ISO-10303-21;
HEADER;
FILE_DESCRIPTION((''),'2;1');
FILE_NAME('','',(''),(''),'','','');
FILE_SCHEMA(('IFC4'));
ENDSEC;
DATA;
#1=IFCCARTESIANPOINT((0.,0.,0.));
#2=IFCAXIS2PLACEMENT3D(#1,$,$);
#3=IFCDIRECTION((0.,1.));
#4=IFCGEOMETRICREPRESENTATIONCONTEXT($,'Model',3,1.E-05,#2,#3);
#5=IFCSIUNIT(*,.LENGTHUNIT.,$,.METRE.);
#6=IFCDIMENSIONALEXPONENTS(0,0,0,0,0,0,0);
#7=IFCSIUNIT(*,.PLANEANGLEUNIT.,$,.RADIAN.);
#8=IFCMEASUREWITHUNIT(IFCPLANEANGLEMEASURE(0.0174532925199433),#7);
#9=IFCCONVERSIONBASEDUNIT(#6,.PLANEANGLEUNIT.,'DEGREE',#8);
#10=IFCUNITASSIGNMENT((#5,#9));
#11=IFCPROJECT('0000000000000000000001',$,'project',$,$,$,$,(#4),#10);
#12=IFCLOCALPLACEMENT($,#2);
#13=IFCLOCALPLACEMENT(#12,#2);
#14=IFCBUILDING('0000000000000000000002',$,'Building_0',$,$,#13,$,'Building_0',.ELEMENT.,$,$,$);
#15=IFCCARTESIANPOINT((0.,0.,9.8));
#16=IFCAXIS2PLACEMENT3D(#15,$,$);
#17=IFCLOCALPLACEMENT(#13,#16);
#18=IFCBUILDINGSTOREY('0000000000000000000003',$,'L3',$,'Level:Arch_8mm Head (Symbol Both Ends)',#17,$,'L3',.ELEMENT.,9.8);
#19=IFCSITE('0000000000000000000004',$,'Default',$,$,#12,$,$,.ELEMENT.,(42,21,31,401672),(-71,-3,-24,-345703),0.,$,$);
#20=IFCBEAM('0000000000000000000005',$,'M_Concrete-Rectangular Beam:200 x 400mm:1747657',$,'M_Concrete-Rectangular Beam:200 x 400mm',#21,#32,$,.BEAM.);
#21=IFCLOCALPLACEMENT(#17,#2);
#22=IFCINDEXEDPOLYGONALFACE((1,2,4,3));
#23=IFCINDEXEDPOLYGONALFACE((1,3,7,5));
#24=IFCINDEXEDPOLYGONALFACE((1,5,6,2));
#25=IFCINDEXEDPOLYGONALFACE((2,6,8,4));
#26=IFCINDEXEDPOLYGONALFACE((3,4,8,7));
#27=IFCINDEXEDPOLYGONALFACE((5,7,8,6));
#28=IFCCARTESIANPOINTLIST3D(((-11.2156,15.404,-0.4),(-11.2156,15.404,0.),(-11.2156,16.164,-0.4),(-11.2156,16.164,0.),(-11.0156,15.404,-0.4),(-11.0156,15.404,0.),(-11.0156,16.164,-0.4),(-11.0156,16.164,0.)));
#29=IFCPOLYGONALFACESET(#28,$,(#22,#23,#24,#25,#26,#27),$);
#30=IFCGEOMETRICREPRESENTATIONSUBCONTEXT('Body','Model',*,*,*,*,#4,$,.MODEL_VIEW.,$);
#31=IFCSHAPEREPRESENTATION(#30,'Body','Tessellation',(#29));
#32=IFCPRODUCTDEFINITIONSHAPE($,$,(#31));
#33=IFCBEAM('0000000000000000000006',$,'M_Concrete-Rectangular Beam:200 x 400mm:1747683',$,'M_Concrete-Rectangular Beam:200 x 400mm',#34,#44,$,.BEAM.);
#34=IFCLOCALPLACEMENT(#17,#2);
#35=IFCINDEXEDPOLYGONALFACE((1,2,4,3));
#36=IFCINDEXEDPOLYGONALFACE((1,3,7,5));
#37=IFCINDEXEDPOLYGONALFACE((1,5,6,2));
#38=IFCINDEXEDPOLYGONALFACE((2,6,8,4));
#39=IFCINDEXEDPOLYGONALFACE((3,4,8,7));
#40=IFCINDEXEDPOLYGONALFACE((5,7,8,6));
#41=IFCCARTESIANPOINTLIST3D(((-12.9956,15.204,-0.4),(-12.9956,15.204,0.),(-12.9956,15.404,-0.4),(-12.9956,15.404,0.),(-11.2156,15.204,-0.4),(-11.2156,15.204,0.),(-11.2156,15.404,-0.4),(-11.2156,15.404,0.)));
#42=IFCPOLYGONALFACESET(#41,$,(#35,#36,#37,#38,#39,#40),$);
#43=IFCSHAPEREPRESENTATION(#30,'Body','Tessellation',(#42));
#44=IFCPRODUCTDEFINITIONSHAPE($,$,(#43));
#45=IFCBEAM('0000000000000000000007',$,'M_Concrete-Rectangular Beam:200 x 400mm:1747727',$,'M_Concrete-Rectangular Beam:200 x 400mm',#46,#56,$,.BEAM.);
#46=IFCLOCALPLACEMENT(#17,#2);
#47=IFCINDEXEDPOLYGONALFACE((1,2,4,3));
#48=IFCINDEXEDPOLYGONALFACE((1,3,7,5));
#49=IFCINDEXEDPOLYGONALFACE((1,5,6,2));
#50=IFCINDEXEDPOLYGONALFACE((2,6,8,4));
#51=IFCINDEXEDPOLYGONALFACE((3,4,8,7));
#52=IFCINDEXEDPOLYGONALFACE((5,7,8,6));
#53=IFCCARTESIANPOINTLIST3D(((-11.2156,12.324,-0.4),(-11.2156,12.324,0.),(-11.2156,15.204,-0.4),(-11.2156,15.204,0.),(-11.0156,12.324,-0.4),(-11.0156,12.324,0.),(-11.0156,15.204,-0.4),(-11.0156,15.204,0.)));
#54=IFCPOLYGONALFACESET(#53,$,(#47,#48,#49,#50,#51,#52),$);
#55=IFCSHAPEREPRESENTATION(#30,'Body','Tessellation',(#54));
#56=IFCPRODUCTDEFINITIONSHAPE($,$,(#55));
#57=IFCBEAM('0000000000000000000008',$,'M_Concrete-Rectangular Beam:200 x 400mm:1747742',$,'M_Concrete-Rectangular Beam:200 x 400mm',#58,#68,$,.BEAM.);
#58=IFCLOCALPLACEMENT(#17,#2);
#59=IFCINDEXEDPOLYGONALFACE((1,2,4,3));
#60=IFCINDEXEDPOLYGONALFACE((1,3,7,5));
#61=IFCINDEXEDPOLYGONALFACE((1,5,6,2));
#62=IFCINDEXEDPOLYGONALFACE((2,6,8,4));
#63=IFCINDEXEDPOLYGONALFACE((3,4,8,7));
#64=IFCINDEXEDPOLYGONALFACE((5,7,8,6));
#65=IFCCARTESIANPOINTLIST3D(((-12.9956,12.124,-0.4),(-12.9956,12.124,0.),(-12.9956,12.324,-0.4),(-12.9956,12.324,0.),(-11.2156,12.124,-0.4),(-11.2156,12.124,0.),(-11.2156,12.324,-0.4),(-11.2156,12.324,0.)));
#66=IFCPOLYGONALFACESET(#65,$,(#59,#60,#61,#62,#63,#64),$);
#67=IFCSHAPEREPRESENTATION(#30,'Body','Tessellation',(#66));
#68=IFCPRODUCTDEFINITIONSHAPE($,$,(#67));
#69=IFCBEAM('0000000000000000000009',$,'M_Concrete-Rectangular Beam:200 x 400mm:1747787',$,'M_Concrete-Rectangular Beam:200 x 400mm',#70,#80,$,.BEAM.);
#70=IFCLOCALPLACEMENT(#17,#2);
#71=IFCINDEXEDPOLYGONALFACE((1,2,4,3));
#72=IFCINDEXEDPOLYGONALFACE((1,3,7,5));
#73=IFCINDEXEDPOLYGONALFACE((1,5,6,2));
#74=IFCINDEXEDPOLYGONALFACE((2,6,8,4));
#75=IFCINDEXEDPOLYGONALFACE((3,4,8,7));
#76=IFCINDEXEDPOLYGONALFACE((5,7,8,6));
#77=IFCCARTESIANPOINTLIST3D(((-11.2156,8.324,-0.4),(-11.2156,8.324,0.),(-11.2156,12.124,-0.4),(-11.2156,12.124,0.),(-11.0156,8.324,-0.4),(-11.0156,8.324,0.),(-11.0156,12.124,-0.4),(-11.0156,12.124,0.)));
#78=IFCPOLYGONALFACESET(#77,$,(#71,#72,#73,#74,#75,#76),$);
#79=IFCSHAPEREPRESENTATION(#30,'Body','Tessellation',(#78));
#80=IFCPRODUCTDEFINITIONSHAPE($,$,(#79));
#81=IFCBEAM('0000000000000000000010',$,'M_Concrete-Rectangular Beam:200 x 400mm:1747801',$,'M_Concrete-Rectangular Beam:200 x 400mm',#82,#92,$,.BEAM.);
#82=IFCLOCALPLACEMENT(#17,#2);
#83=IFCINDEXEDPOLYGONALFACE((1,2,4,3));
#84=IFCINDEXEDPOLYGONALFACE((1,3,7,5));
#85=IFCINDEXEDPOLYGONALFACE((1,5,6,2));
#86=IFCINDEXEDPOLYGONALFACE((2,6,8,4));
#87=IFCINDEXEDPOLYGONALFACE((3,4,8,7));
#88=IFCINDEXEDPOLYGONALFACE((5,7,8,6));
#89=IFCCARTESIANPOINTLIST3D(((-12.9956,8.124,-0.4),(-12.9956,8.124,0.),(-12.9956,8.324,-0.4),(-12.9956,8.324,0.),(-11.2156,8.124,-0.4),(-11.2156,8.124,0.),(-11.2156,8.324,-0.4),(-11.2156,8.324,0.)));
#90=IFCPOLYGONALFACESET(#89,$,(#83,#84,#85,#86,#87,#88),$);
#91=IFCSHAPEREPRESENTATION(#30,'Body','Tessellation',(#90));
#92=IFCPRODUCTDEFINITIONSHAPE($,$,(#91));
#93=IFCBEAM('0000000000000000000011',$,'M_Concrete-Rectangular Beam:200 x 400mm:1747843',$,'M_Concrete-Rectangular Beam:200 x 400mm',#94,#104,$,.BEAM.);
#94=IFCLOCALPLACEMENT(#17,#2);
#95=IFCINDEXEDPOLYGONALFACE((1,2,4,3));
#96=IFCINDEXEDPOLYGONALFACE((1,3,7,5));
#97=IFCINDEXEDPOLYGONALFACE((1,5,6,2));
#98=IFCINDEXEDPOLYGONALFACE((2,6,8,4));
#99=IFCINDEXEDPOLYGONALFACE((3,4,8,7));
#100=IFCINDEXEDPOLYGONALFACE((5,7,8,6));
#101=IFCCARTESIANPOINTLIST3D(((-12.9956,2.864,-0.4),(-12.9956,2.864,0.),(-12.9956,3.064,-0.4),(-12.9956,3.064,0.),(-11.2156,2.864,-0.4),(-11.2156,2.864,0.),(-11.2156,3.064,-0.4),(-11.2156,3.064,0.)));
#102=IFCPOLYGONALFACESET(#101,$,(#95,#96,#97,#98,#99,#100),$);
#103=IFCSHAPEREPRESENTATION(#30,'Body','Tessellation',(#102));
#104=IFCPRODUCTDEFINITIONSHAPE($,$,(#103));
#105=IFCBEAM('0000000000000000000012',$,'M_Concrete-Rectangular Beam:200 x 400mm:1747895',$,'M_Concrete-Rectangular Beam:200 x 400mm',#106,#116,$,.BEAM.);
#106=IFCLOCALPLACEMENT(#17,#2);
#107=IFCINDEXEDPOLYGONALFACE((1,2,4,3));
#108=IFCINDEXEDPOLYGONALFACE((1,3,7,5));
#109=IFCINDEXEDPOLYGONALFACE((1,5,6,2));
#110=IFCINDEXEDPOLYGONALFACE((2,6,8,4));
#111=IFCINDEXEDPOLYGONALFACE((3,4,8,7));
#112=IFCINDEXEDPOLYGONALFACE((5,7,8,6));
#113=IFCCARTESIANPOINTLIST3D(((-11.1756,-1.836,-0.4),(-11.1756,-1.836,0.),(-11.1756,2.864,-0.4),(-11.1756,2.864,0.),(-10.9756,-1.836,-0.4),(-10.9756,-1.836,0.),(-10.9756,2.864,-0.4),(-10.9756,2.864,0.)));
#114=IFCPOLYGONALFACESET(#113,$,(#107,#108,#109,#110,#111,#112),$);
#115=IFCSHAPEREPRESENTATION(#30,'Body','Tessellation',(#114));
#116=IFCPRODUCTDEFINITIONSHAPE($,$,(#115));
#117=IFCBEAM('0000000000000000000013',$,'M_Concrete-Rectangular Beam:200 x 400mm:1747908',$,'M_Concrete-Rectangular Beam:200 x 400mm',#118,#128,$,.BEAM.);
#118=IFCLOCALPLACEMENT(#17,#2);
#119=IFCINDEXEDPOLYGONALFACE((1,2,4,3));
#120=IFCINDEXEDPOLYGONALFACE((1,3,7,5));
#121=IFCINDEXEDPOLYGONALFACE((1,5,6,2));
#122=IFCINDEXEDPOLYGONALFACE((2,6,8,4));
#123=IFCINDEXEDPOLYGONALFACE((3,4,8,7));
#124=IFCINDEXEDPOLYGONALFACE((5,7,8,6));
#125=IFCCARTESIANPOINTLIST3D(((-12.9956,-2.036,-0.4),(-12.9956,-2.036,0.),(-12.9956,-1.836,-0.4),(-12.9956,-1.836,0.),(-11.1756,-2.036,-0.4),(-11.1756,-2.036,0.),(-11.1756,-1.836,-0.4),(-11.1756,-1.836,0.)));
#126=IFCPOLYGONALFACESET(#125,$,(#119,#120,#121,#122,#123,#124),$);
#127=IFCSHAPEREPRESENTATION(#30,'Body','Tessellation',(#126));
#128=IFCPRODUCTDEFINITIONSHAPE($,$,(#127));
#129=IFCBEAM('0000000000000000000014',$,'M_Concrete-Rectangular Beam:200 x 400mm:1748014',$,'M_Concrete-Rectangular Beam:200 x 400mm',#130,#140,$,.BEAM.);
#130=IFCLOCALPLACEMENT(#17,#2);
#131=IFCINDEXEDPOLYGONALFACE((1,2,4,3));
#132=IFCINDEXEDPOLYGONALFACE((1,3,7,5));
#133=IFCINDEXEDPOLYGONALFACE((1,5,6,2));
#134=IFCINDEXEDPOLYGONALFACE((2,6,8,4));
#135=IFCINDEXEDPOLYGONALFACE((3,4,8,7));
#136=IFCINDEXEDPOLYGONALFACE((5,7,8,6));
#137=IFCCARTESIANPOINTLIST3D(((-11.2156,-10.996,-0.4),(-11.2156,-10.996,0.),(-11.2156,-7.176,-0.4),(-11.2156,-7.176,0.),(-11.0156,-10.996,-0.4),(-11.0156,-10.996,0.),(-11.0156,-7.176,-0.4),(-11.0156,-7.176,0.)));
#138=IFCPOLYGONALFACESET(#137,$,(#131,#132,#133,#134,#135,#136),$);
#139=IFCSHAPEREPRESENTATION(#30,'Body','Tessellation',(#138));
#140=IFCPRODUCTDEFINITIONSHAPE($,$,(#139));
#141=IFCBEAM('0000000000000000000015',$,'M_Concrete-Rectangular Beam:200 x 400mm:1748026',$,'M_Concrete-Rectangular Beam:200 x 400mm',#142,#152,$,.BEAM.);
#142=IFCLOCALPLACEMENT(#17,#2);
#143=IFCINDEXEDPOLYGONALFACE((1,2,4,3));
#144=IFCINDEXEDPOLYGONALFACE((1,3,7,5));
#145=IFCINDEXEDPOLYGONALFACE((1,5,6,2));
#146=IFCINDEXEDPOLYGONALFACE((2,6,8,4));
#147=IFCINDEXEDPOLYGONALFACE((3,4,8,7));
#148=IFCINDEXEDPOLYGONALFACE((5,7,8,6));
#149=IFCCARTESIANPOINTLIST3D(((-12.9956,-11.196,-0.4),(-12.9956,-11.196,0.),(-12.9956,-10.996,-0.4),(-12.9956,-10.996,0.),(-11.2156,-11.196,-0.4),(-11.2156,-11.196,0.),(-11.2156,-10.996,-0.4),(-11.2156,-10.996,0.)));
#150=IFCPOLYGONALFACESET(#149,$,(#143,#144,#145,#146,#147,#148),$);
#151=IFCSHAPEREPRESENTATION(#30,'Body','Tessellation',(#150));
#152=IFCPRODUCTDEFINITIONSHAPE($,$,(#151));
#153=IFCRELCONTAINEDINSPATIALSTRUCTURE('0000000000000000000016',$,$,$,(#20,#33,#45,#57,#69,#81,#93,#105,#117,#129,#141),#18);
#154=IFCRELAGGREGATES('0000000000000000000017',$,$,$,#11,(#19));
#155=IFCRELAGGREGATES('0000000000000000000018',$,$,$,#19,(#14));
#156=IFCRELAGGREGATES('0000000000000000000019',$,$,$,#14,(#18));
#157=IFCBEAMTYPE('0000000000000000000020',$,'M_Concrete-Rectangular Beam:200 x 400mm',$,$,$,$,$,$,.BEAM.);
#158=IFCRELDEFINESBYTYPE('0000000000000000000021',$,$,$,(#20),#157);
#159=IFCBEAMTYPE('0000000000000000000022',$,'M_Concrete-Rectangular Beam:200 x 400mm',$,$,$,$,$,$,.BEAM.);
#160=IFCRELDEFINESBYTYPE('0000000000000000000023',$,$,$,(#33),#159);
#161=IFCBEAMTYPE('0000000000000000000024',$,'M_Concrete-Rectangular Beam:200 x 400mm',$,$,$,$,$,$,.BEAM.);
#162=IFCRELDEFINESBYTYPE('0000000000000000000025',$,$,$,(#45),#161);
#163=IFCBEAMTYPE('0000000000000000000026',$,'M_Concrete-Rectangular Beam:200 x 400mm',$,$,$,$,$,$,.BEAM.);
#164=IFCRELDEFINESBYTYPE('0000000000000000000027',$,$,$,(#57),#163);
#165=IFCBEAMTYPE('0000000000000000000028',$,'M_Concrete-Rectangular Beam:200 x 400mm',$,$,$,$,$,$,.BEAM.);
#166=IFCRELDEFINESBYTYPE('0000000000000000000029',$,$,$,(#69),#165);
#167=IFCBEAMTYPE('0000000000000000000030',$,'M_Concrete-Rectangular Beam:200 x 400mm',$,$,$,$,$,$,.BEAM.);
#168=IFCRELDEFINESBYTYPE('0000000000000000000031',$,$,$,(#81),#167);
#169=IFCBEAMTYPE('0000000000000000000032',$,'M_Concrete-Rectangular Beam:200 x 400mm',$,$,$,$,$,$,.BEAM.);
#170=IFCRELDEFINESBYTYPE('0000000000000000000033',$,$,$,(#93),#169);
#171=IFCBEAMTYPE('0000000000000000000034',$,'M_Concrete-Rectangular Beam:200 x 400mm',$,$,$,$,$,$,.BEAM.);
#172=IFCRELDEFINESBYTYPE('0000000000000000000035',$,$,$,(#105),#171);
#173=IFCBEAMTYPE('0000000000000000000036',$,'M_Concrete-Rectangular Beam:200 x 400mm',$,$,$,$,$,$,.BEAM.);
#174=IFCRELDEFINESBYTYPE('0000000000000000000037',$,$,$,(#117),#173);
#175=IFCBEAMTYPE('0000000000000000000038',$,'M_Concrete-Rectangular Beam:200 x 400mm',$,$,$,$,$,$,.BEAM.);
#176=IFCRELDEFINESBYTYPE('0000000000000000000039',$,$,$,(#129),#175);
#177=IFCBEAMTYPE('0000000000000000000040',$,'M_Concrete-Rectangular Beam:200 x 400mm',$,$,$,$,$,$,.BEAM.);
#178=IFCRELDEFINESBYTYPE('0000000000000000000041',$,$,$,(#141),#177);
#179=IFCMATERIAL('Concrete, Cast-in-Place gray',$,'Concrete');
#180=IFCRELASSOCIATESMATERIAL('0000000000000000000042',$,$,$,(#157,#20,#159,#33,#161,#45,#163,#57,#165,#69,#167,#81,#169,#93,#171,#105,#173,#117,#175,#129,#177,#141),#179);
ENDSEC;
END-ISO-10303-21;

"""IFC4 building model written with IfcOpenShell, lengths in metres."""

from ifc_helpers import new_model, entity, si_unit, converted_unit, direction, frame, origin, place, context, subcontext, project, spatial, indexed_curve, outline, extrude, source, transform, mapped, material, type_object, type_shapes, element, save


model = new_model("IFC4")

# Units and contexts
model_context = context("Model", 3, precision=1e-05, world=origin(), true_north=direction((0.0, 1.0)))
body_context = subcontext(model_context, "Body", "Model", "MODEL_VIEW")
ifc_project = project(units=[si_unit("LENGTHUNIT", "METRE"), converted_unit("PLANEANGLEUNIT", "DEGREE", entity("IfcPlaneAngleMeasure", 0.0174532925199433), si_unit("PLANEANGLEUNIT", "RADIAN"), dimensions=[0, 0, 0, 0, 0, 0, 0])], contexts=[model_context])

# Site, building, storey
site_placement = place(None, origin())
site = spatial("IfcSite", under=ifc_project, at=site_placement, Name="Default", CompositionType="ELEMENT", RefLatitude=(42, 21, 31, 401672), RefLongitude=(-71, -3, -24, -345703), RefElevation=0.0)
building_placement = place(site_placement, origin())
building = spatial("IfcBuilding", under=site, at=building_placement, Name="Building_0", LongName="Building_0", CompositionType="ELEMENT")
storey_placement = place(building_placement, frame((0.0, 0.0, 9.8)))
storey = spatial("IfcBuildingStorey", under=building, at=storey_placement, Name="L3", ObjectType="Level:Arch_8mm Head (Symbol Both Ends)", LongName="L3", CompositionType="ELEMENT", Elevation=9.8)

# Beams
ifc_material_1 = material(Name="Concrete, Cast-in-Place gray", Category="Concrete")
beam_type_1 = type_object("IfcBeamType", Name="M_Concrete-Rectangular Beam:200 x 400mm", PredefinedType="BEAM", material=ifc_material_1)
shared_shape_1 = source(origin(), body_context, "Body", "SweptSolid", [
    extrude(outline(indexed_curve([(-0.1, -0.2), (0.1, -0.2), (0.1, 0.2), (-0.1, 0.2), (-0.1, -0.2)], self_intersect=False)), frame((-11.1156, 15.404, 9.6), z_axis=(0.0, 1.0, 0.0), x_axis=(-1.0, 0.0, 0.0)), (0.0, 0.0, 1.0), 0.76),
])
type_shapes(beam_type_1, [shared_shape_1])
beam_1_placement = place(storey_placement, frame((0.0, 0.0, -9.8)))
element("IfcBeam", 1, at=beam_1_placement, inside=storey, type_object=beam_type_1, material=ifc_material_1, Name="M_Concrete-Rectangular Beam:200 x 400mm:1747657", ObjectType="M_Concrete-Rectangular Beam:200 x 400mm", PredefinedType="BEAM", context=body_context, shape_type="MappedRepresentation", body=[
    mapped(shared_shape_1, transform((0.0, 0.0, 0.0), scale=1.0)),
])
beam_type_2 = type_object("IfcBeamType", Name="M_Concrete-Rectangular Beam:200 x 400mm", PredefinedType="BEAM", material=ifc_material_1)
shared_shape_2 = source(origin(), body_context, "Body", "SweptSolid", [
    extrude(outline(indexed_curve([(-0.2, -0.1), (0.2, -0.1), (0.2, 0.1), (-0.2, 0.1), (-0.2, -0.1)], self_intersect=False)), frame((-11.2156, 15.304, 9.6), z_axis=(-1.0, 0.0, 0.0), x_axis=(0.0, 0.0, -1.0)), (0.0, 0.0, 1.0), 1.78),
])
type_shapes(beam_type_2, [shared_shape_2])
beam_2_placement = place(storey_placement, frame((0.0, 0.0, -9.8)))
element("IfcBeam", 2, at=beam_2_placement, inside=storey, type_object=beam_type_2, material=ifc_material_1, Name="M_Concrete-Rectangular Beam:200 x 400mm:1747683", ObjectType="M_Concrete-Rectangular Beam:200 x 400mm", PredefinedType="BEAM", context=body_context, shape_type="MappedRepresentation", body=[
    mapped(shared_shape_2, transform((0.0, 0.0, 0.0), scale=1.0)),
])
beam_type_3 = type_object("IfcBeamType", Name="M_Concrete-Rectangular Beam:200 x 400mm", PredefinedType="BEAM", material=ifc_material_1)
shared_shape_3 = source(origin(), body_context, "Body", "SweptSolid", [
    extrude(outline(indexed_curve([(-0.1, -0.2), (0.1, -0.2), (0.1, 0.2), (-0.1, 0.2), (-0.1, -0.2)], self_intersect=False)), frame((-11.1156, 15.204, 9.6), z_axis=(0.0, -1.0, 0.0), x_axis=(-1.0, 0.0, 0.0)), (0.0, 0.0, 1.0), 2.88),
])
type_shapes(beam_type_3, [shared_shape_3])
beam_3_placement = place(storey_placement, frame((0.0, 0.0, -9.8)))
element("IfcBeam", 3, at=beam_3_placement, inside=storey, type_object=beam_type_3, material=ifc_material_1, Name="M_Concrete-Rectangular Beam:200 x 400mm:1747727", ObjectType="M_Concrete-Rectangular Beam:200 x 400mm", PredefinedType="BEAM", context=body_context, shape_type="MappedRepresentation", body=[
    mapped(shared_shape_3, transform((0.0, 0.0, 0.0), scale=1.0)),
])
beam_type_4 = type_object("IfcBeamType", Name="M_Concrete-Rectangular Beam:200 x 400mm", PredefinedType="BEAM", material=ifc_material_1)
shared_shape_4 = source(origin(), body_context, "Body", "SweptSolid", [
    extrude(outline(indexed_curve([(-0.2, -0.1), (0.2, -0.1), (0.2, 0.1), (-0.2, 0.1), (-0.2, -0.1)], self_intersect=False)), frame((-11.2156, 12.224, 9.6), z_axis=(-1.0, 0.0, 0.0), x_axis=(0.0, 0.0, -1.0)), (0.0, 0.0, 1.0), 1.78),
])
type_shapes(beam_type_4, [shared_shape_4])
beam_4_placement = place(storey_placement, frame((0.0, 0.0, -9.8)))
element("IfcBeam", 4, at=beam_4_placement, inside=storey, type_object=beam_type_4, material=ifc_material_1, Name="M_Concrete-Rectangular Beam:200 x 400mm:1747742", ObjectType="M_Concrete-Rectangular Beam:200 x 400mm", PredefinedType="BEAM", context=body_context, shape_type="MappedRepresentation", body=[
    mapped(shared_shape_4, transform((0.0, 0.0, 0.0), scale=1.0)),
])
beam_type_5 = type_object("IfcBeamType", Name="M_Concrete-Rectangular Beam:200 x 400mm", PredefinedType="BEAM", material=ifc_material_1)
shared_shape_5 = source(origin(), body_context, "Body", "SweptSolid", [
    extrude(outline(indexed_curve([(-0.1, -0.2), (0.1, -0.2), (0.1, 0.2), (-0.1, 0.2), (-0.1, -0.2)], self_intersect=False)), frame((-11.1156, 12.124, 9.6), z_axis=(0.0, -1.0, 0.0), x_axis=(-1.0, 0.0, 0.0)), (0.0, 0.0, 1.0), 3.8),
])
type_shapes(beam_type_5, [shared_shape_5])
beam_5_placement = place(storey_placement, frame((0.0, 0.0, -9.8)))
element("IfcBeam", 5, at=beam_5_placement, inside=storey, type_object=beam_type_5, material=ifc_material_1, Name="M_Concrete-Rectangular Beam:200 x 400mm:1747787", ObjectType="M_Concrete-Rectangular Beam:200 x 400mm", PredefinedType="BEAM", context=body_context, shape_type="MappedRepresentation", body=[
    mapped(shared_shape_5, transform((0.0, 0.0, 0.0), scale=1.0)),
])
beam_type_6 = type_object("IfcBeamType", Name="M_Concrete-Rectangular Beam:200 x 400mm", PredefinedType="BEAM", material=ifc_material_1)
shared_shape_6 = source(origin(), body_context, "Body", "SweptSolid", [
    extrude(outline(indexed_curve([(-0.2, -0.1), (0.2, -0.1), (0.2, 0.1), (-0.2, 0.1), (-0.2, -0.1)], self_intersect=False)), frame((-11.2156, 8.224, 9.6), z_axis=(-1.0, 0.0, 0.0), x_axis=(0.0, 0.0, -1.0)), (0.0, 0.0, 1.0), 1.78),
])
type_shapes(beam_type_6, [shared_shape_6])
beam_6_placement = place(storey_placement, frame((0.0, 0.0, -9.8)))
element("IfcBeam", 6, at=beam_6_placement, inside=storey, type_object=beam_type_6, material=ifc_material_1, Name="M_Concrete-Rectangular Beam:200 x 400mm:1747801", ObjectType="M_Concrete-Rectangular Beam:200 x 400mm", PredefinedType="BEAM", context=body_context, shape_type="MappedRepresentation", body=[
    mapped(shared_shape_6, transform((0.0, 0.0, 0.0), scale=1.0)),
])
beam_type_7 = type_object("IfcBeamType", Name="M_Concrete-Rectangular Beam:200 x 400mm", PredefinedType="BEAM", material=ifc_material_1)
shared_shape_7 = source(origin(), body_context, "Body", "SweptSolid", [
    extrude(outline(indexed_curve([(-0.2, -0.1), (0.2, -0.1), (0.2, 0.1), (-0.2, 0.1), (-0.2, -0.1)], self_intersect=False)), frame((-11.2156, 2.964, 9.6), z_axis=(-1.0, 0.0, 0.0), x_axis=(0.0, 0.0, -1.0)), (0.0, 0.0, 1.0), 1.78),
])
type_shapes(beam_type_7, [shared_shape_7])
beam_7_placement = place(storey_placement, frame((0.0, 0.0, -9.8)))
element("IfcBeam", 7, at=beam_7_placement, inside=storey, type_object=beam_type_7, material=ifc_material_1, Name="M_Concrete-Rectangular Beam:200 x 400mm:1747843", ObjectType="M_Concrete-Rectangular Beam:200 x 400mm", PredefinedType="BEAM", context=body_context, shape_type="MappedRepresentation", body=[
    mapped(shared_shape_7, transform((0.0, 0.0, 0.0), scale=1.0)),
])
beam_type_8 = type_object("IfcBeamType", Name="M_Concrete-Rectangular Beam:200 x 400mm", PredefinedType="BEAM", material=ifc_material_1)
shared_shape_8 = source(origin(), body_context, "Body", "SweptSolid", [
    extrude(outline(indexed_curve([(-0.1, -0.2), (0.1, -0.2), (0.1, 0.2), (-0.1, 0.2), (-0.1, -0.2)], self_intersect=False)), frame((-11.0756, 2.864, 9.6), z_axis=(0.0, -1.0, 0.0), x_axis=(-1.0, 0.0, 0.0)), (0.0, 0.0, 1.0), 4.7),
])
type_shapes(beam_type_8, [shared_shape_8])
beam_8_placement = place(storey_placement, frame((0.0, 0.0, -9.8)))
element("IfcBeam", 8, at=beam_8_placement, inside=storey, type_object=beam_type_8, material=ifc_material_1, Name="M_Concrete-Rectangular Beam:200 x 400mm:1747895", ObjectType="M_Concrete-Rectangular Beam:200 x 400mm", PredefinedType="BEAM", context=body_context, shape_type="MappedRepresentation", body=[
    mapped(shared_shape_8, transform((0.0, 0.0, 0.0), scale=1.0)),
])
beam_type_9 = type_object("IfcBeamType", Name="M_Concrete-Rectangular Beam:200 x 400mm", PredefinedType="BEAM", material=ifc_material_1)
shared_shape_9 = source(origin(), body_context, "Body", "SweptSolid", [
    extrude(outline(indexed_curve([(-0.2, -0.1), (0.2, -0.1), (0.2, 0.1), (-0.2, 0.1), (-0.2, -0.1)], self_intersect=False)), frame((-11.1756, -1.936, 9.6), z_axis=(-1.0, 0.0, 0.0), x_axis=(0.0, 0.0, -1.0)), (0.0, 0.0, 1.0), 1.82),
])
type_shapes(beam_type_9, [shared_shape_9])
beam_9_placement = place(storey_placement, frame((0.0, 0.0, -9.8)))
element("IfcBeam", 9, at=beam_9_placement, inside=storey, type_object=beam_type_9, material=ifc_material_1, Name="M_Concrete-Rectangular Beam:200 x 400mm:1747908", ObjectType="M_Concrete-Rectangular Beam:200 x 400mm", PredefinedType="BEAM", context=body_context, shape_type="MappedRepresentation", body=[
    mapped(shared_shape_9, transform((0.0, 0.0, 0.0), scale=1.0)),
])
beam_type_10 = type_object("IfcBeamType", Name="M_Concrete-Rectangular Beam:200 x 400mm", PredefinedType="BEAM", material=ifc_material_1)
shared_shape_10 = source(origin(), body_context, "Body", "SweptSolid", [
    extrude(outline(indexed_curve([(-0.1, -0.2), (0.1, -0.2), (0.1, 0.2), (-0.1, 0.2), (-0.1, -0.2)], self_intersect=False)), frame((-11.1156, -7.176, 9.6), z_axis=(0.0, -1.0, 0.0), x_axis=(-1.0, 0.0, 0.0)), (0.0, 0.0, 1.0), 3.82),
])
type_shapes(beam_type_10, [shared_shape_10])
beam_10_placement = place(storey_placement, frame((0.0, 0.0, -9.8)))
element("IfcBeam", 10, at=beam_10_placement, inside=storey, type_object=beam_type_10, material=ifc_material_1, Name="M_Concrete-Rectangular Beam:200 x 400mm:1748014", ObjectType="M_Concrete-Rectangular Beam:200 x 400mm", PredefinedType="BEAM", context=body_context, shape_type="MappedRepresentation", body=[
    mapped(shared_shape_10, transform((0.0, 0.0, 0.0), scale=1.0)),
])
beam_type_11 = type_object("IfcBeamType", Name="M_Concrete-Rectangular Beam:200 x 400mm", PredefinedType="BEAM", material=ifc_material_1)
shared_shape_11 = source(origin(), body_context, "Body", "SweptSolid", [
    extrude(outline(indexed_curve([(-0.2, -0.1), (0.2, -0.1), (0.2, 0.1), (-0.2, 0.1), (-0.2, -0.1)], self_intersect=False)), frame((-11.2156, -11.096, 9.6), z_axis=(-1.0, 0.0, 0.0), x_axis=(0.0, 0.0, -1.0)), (0.0, 0.0, 1.0), 1.78),
])
type_shapes(beam_type_11, [shared_shape_11])
beam_11_placement = place(storey_placement, frame((0.0, 0.0, -9.8)))
element("IfcBeam", 11, at=beam_11_placement, inside=storey, type_object=beam_type_11, material=ifc_material_1, Name="M_Concrete-Rectangular Beam:200 x 400mm:1748026", ObjectType="M_Concrete-Rectangular Beam:200 x 400mm", PredefinedType="BEAM", context=body_context, shape_type="MappedRepresentation", body=[
    mapped(shared_shape_11, transform((0.0, 0.0, 0.0), scale=1.0)),
])

save(model, "model.ifc")
